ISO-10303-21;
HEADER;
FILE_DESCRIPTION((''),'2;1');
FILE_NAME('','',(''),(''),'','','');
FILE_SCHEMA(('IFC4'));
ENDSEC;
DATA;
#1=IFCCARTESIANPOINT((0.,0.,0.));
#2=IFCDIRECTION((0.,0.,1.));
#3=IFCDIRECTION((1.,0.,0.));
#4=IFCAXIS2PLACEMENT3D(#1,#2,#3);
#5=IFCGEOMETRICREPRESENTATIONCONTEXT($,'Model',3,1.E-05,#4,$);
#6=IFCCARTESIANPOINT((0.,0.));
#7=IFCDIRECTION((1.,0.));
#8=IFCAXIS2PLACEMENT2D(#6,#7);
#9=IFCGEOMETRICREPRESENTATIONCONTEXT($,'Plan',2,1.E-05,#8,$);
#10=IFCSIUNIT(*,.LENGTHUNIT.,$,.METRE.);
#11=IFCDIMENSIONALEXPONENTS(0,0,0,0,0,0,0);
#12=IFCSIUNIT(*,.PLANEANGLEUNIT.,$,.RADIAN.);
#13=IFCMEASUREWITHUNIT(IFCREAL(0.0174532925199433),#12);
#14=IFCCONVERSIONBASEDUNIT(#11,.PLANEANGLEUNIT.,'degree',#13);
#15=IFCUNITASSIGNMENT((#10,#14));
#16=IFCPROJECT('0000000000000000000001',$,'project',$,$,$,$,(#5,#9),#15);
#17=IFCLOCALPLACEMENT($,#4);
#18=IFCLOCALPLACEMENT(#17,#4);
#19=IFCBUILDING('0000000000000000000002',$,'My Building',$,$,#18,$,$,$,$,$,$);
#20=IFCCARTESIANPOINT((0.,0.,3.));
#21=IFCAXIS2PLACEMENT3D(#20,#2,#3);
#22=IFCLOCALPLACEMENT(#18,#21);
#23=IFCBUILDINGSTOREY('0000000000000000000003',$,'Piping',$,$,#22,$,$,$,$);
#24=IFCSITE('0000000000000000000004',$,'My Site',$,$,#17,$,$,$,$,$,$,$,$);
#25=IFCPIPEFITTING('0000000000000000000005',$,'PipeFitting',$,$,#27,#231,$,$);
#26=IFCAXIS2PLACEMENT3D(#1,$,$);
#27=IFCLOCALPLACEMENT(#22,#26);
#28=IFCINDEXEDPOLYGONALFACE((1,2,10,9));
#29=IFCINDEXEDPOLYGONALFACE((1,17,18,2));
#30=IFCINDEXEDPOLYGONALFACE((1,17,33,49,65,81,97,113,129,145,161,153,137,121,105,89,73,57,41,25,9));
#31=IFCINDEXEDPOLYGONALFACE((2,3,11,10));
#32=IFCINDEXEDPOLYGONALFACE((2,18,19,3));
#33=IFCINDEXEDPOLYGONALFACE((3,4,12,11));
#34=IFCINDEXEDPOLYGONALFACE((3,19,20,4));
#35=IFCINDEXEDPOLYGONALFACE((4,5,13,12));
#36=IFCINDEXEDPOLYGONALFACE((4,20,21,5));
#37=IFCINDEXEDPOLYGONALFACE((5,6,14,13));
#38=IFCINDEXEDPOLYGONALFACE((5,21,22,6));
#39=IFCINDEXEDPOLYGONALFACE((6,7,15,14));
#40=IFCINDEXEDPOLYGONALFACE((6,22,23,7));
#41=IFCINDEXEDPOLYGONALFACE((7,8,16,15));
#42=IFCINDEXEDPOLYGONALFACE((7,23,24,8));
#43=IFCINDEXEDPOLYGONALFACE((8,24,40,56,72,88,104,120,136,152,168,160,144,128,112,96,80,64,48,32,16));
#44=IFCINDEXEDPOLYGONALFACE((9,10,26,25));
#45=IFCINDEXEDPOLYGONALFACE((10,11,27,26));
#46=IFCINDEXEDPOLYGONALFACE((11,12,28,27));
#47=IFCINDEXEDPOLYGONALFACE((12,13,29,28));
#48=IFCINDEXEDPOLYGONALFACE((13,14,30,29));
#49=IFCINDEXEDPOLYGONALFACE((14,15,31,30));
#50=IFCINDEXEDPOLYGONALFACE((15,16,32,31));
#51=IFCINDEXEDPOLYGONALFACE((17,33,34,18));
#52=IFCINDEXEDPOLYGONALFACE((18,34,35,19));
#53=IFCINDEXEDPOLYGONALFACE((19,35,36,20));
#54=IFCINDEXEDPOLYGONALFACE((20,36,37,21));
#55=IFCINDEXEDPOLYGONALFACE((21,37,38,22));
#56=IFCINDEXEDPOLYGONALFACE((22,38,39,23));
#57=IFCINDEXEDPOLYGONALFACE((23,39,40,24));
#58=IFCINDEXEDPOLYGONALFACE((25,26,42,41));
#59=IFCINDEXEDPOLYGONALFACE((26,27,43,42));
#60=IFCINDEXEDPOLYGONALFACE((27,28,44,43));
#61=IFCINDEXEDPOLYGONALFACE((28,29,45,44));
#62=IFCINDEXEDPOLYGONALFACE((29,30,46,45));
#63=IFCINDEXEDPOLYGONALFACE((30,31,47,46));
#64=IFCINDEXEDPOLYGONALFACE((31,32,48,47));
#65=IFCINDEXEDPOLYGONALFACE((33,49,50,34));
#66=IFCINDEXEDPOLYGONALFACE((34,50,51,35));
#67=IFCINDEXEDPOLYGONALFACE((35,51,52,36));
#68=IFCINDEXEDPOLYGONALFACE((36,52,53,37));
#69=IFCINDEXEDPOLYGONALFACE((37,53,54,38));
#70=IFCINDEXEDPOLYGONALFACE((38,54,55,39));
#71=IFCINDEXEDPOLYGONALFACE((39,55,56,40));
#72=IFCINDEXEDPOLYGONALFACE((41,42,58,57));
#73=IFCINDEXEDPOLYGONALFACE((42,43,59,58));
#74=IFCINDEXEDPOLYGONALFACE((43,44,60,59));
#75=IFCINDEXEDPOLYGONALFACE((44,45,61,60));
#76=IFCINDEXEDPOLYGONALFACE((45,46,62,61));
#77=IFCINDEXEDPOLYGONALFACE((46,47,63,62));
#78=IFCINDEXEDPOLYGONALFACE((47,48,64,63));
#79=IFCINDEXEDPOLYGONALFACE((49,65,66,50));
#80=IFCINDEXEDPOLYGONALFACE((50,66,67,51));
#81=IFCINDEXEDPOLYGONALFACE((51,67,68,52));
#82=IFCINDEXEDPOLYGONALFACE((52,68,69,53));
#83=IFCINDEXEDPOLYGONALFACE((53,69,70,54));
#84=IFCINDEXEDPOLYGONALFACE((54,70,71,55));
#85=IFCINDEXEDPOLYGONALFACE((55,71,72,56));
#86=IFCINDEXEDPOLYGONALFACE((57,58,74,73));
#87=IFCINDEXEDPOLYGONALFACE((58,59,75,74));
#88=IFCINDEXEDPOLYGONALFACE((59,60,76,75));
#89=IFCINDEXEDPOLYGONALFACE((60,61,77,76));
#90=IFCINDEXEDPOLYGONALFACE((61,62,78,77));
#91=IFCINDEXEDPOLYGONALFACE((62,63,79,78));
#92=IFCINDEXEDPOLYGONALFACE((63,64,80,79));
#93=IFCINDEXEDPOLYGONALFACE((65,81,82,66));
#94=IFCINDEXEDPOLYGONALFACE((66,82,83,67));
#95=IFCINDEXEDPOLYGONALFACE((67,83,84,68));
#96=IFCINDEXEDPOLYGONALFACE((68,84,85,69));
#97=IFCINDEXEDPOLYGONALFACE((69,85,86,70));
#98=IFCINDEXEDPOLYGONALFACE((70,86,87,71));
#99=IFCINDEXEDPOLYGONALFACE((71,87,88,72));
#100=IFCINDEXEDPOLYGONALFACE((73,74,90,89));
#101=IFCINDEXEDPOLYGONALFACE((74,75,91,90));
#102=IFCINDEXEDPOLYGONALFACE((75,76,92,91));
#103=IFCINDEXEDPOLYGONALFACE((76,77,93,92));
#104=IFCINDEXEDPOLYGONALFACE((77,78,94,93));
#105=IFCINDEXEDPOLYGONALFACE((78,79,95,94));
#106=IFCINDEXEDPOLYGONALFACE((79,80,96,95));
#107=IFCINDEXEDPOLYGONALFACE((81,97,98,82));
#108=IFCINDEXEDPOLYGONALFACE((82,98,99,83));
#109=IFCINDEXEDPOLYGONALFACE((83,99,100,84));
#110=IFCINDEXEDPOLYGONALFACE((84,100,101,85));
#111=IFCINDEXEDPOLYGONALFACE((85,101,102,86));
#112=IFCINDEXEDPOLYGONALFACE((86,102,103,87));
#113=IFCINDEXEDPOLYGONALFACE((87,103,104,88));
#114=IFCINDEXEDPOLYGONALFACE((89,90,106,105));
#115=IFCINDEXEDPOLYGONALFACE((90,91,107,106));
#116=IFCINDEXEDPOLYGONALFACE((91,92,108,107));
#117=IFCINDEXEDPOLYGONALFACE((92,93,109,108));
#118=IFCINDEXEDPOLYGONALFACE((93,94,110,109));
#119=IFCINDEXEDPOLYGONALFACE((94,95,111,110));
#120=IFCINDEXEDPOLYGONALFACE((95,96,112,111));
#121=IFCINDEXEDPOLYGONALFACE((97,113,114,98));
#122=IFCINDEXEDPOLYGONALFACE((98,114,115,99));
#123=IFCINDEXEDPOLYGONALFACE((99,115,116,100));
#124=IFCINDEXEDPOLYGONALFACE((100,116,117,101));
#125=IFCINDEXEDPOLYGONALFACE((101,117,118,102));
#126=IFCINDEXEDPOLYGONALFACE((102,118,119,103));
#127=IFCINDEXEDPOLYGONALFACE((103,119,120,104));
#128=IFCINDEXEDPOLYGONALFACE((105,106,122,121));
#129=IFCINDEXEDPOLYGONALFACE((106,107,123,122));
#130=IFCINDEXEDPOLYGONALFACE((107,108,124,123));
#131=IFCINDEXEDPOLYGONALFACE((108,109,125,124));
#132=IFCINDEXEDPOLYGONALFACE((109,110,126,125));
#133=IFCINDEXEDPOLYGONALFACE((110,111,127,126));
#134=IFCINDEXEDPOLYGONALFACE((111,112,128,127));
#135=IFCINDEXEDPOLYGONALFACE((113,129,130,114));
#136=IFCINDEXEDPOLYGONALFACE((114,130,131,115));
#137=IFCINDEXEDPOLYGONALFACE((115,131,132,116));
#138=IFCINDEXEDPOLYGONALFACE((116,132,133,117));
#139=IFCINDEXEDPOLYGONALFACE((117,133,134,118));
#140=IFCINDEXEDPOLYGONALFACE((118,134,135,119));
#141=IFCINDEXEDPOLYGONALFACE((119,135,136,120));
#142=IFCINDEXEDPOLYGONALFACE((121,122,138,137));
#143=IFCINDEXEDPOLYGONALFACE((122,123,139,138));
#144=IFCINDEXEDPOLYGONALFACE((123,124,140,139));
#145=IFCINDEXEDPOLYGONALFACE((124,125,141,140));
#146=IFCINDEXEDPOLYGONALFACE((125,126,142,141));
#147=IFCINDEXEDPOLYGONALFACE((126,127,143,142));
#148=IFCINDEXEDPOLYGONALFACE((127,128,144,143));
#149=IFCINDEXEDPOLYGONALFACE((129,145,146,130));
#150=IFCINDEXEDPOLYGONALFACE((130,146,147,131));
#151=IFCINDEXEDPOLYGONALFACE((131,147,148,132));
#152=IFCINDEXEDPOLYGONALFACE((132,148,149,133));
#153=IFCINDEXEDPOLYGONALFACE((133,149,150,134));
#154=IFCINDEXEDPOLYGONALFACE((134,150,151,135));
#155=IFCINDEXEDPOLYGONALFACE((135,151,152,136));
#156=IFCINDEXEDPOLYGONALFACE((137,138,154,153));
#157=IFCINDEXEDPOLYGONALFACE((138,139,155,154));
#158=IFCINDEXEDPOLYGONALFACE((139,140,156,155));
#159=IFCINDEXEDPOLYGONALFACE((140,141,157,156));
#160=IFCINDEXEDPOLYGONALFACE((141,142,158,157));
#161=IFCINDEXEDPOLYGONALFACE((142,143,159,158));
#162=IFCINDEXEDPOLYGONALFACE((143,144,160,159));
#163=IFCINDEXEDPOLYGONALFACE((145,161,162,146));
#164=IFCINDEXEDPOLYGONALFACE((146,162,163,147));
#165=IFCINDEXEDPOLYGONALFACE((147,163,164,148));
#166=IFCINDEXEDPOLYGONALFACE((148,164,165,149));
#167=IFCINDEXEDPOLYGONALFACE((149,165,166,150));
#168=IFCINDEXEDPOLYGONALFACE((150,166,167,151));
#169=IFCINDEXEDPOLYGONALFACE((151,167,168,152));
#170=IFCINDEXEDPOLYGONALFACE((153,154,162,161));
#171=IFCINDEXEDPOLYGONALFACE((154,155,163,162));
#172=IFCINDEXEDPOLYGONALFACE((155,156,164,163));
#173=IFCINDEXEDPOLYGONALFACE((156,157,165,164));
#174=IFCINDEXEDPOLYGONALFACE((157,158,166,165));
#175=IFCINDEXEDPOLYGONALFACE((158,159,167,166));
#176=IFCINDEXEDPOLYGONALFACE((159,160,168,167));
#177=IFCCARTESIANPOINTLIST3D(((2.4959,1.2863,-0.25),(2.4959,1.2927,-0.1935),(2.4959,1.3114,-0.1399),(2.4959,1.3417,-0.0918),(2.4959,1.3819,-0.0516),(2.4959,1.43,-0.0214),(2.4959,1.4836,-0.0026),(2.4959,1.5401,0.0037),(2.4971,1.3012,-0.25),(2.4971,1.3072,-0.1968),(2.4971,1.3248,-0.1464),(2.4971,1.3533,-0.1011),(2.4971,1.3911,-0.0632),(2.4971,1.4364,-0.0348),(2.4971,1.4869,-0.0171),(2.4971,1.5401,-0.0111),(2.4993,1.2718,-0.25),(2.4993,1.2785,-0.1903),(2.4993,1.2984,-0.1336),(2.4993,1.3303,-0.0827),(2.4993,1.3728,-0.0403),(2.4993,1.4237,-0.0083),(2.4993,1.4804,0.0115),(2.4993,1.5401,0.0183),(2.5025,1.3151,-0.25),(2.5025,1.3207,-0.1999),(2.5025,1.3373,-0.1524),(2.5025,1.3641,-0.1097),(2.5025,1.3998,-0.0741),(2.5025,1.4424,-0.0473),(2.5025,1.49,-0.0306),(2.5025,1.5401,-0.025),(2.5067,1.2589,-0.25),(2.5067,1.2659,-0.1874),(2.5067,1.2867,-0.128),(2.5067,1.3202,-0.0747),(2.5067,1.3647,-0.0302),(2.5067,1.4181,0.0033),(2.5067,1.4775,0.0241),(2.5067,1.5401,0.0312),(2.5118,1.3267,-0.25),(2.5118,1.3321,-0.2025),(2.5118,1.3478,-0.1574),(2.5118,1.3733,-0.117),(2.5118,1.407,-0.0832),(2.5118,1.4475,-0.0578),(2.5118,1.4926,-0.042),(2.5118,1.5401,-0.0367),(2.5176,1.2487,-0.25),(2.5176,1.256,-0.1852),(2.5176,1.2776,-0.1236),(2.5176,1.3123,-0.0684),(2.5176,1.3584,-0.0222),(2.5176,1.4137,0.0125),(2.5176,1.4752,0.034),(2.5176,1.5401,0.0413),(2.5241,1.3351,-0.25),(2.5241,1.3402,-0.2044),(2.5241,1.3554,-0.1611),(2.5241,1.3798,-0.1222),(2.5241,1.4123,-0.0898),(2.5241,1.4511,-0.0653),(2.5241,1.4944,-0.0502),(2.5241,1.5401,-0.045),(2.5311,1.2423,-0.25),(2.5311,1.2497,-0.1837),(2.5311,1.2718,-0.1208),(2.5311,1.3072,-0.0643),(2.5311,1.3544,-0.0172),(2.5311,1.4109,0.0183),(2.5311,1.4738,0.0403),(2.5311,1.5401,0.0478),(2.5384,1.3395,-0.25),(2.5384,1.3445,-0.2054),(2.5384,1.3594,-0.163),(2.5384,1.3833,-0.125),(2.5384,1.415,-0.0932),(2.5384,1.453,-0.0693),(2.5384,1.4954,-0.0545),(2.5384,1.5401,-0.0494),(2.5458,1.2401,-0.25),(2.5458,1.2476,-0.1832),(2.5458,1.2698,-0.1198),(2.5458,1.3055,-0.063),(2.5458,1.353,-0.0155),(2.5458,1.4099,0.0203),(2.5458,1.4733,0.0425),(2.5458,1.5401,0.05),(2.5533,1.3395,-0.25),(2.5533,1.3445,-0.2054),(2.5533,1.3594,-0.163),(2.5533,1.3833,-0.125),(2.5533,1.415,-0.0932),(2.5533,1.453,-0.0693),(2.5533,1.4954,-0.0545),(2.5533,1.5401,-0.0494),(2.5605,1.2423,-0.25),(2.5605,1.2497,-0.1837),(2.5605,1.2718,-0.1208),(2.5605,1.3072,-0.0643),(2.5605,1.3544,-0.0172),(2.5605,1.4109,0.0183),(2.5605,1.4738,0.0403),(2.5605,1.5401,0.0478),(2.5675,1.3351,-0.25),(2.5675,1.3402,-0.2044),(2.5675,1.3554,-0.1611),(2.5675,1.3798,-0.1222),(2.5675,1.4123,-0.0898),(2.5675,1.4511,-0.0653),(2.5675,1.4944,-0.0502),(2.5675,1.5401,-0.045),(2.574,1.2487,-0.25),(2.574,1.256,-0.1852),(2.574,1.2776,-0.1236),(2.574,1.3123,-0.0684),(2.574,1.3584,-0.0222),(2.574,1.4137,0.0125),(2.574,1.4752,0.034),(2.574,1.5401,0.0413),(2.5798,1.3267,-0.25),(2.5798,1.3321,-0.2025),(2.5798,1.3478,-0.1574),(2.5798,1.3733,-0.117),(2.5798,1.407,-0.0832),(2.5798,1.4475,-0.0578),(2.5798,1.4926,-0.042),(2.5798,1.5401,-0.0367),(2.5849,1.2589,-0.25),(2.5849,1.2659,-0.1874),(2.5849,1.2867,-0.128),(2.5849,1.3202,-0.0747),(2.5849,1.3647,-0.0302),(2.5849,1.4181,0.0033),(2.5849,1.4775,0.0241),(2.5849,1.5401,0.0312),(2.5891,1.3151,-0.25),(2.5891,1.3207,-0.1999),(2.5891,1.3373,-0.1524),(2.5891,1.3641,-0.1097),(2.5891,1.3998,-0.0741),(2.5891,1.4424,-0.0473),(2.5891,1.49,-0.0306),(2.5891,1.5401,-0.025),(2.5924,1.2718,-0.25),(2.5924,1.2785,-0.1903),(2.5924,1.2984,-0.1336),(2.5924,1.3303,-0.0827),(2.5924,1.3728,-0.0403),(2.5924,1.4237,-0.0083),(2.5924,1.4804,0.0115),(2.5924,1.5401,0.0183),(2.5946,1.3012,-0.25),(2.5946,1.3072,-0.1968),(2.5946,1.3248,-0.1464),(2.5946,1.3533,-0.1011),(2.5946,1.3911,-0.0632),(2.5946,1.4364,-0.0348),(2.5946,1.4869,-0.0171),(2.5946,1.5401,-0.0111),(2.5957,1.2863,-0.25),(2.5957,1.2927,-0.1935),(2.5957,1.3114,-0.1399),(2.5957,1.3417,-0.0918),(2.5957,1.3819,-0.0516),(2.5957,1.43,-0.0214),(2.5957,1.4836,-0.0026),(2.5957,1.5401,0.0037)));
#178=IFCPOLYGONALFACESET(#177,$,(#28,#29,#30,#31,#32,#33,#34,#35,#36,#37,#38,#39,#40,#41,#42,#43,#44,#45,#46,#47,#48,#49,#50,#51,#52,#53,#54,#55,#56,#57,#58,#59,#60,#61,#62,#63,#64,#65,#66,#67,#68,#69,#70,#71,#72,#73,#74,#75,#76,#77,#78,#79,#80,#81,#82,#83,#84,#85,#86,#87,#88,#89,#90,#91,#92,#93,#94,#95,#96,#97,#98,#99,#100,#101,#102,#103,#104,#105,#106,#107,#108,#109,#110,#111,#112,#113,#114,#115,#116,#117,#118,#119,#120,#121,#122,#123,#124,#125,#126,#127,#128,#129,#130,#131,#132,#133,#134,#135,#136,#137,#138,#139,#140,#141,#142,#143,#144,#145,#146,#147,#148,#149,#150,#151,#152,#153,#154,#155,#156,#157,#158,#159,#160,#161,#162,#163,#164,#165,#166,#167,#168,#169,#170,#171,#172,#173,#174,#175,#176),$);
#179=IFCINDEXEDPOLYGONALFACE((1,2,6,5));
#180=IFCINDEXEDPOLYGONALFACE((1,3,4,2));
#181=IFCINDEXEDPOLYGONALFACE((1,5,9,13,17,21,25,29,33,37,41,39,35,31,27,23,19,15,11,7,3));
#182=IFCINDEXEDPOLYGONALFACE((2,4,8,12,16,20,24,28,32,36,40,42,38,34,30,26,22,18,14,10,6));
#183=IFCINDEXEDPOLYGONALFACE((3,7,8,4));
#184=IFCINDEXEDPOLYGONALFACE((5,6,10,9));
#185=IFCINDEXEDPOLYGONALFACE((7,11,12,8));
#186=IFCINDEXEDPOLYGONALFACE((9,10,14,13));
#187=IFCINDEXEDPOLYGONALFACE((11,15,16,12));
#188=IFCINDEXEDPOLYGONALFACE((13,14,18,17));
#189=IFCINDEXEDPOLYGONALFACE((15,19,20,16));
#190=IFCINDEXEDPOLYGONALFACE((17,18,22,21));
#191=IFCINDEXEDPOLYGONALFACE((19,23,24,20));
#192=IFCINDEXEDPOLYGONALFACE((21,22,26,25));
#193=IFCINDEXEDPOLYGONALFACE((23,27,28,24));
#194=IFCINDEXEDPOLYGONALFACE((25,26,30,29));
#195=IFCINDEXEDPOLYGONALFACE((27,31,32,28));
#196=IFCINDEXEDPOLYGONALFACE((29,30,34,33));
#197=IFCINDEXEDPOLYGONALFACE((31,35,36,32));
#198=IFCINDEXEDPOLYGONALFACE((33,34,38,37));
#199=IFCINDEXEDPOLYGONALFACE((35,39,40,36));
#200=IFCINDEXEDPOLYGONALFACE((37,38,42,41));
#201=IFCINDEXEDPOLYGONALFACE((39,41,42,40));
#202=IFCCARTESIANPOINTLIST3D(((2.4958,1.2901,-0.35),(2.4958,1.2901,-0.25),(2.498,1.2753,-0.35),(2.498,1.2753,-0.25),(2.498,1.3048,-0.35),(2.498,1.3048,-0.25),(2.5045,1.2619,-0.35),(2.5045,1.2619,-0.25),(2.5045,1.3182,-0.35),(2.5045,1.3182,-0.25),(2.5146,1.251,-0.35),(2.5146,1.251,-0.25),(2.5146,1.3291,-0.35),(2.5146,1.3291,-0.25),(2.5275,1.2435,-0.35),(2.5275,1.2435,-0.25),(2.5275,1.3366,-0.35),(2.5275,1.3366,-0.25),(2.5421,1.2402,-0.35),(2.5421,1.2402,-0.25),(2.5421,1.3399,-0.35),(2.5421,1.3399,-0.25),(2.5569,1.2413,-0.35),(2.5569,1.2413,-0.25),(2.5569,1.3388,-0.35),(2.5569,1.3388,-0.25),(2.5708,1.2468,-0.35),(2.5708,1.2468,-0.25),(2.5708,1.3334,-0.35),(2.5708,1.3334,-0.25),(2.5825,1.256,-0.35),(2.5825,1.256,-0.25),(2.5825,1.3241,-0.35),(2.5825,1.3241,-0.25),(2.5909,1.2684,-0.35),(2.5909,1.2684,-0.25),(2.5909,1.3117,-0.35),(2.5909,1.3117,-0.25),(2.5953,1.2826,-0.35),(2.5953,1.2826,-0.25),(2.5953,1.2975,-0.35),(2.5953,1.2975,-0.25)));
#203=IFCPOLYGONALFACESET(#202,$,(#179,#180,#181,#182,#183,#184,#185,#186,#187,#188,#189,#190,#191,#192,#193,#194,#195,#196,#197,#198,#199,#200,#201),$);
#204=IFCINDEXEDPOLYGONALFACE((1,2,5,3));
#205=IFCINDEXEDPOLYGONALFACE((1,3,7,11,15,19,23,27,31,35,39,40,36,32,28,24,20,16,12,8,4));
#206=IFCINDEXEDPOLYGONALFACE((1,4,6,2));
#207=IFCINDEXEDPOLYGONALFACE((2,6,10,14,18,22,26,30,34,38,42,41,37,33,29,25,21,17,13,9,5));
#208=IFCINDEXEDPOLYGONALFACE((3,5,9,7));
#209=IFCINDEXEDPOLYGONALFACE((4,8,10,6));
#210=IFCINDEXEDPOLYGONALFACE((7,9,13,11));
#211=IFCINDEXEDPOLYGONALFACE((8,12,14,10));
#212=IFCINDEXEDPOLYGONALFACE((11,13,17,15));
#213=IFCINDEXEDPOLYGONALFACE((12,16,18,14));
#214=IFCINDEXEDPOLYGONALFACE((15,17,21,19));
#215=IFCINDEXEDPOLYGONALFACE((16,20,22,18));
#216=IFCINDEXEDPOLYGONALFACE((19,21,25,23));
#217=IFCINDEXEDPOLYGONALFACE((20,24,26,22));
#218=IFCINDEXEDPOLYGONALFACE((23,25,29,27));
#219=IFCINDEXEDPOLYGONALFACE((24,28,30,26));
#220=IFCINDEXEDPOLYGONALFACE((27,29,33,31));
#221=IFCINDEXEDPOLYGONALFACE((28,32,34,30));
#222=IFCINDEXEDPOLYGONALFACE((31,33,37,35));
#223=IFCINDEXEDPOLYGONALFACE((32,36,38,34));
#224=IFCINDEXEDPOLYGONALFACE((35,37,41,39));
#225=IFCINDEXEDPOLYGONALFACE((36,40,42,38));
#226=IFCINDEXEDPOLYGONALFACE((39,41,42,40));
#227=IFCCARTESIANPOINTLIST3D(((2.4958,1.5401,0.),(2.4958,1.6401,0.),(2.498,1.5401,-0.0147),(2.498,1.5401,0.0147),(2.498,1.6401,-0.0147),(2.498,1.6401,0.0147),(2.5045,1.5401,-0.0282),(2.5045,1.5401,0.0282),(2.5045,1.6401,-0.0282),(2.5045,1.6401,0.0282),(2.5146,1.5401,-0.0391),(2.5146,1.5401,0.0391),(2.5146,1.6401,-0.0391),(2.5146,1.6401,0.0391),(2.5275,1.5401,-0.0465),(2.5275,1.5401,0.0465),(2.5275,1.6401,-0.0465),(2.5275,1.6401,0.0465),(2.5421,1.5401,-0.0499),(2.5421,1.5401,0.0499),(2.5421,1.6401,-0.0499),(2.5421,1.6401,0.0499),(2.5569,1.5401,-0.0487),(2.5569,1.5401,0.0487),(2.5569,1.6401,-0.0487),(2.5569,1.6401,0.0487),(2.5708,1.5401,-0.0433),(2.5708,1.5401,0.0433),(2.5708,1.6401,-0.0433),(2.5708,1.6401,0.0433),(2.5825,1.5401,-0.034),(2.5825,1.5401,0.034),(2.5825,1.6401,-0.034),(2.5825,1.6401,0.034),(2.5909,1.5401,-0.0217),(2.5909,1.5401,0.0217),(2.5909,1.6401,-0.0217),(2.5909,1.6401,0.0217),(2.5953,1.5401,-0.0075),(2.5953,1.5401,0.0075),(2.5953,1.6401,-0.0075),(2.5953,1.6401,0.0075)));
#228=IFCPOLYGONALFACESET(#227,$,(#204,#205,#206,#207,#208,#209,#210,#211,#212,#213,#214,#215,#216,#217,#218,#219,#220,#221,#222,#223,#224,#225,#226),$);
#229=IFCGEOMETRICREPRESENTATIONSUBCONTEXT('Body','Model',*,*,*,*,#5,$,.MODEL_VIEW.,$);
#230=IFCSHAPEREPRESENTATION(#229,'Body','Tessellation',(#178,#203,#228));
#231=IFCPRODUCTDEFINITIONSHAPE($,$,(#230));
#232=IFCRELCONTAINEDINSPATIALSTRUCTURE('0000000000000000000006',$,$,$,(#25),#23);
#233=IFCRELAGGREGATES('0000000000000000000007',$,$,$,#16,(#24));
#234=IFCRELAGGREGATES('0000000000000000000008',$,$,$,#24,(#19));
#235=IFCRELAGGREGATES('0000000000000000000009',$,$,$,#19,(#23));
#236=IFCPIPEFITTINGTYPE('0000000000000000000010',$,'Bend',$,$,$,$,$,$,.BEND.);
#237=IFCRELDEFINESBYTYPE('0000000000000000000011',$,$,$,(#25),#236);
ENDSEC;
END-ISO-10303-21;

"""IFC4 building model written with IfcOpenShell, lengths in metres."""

from ifc_helpers import new_model, entity, si_unit, converted_unit, frame, origin_with_axes, origin_2d_with_axis, place, context, subcontext, project, spatial, circle, extrude, source, transform, mapped, type_object, type_shapes, element, save


model = new_model("IFC4")

# Units and contexts
model_context = context("Model", 3, precision=1e-05, world=origin_with_axes())
plan_context = context("Plan", 2, precision=1e-05, world=origin_2d_with_axis())
body_context = subcontext(model_context, "Body", "Model", "MODEL_VIEW")
ifc_project = project(units=[si_unit("LENGTHUNIT", "METRE"), converted_unit("PLANEANGLEUNIT", "degree", entity("IfcReal", 0.0174532925199433), si_unit("PLANEANGLEUNIT", "RADIAN"), dimensions=[0, 0, 0, 0, 0, 0, 0])], contexts=[model_context, plan_context])

# Site, building, storey
site_placement = place(None, origin_with_axes())
site = spatial("IfcSite", under=ifc_project, at=site_placement, Name="My Site")
building_placement = place(site_placement, origin_with_axes())
building = spatial("IfcBuilding", under=site, at=building_placement, Name="My Building")
storey_placement = place(building_placement, frame((0.0, 0.0, 3.0), z_axis=(0.0, 0.0, 1.0), x_axis=(1.0, 0.0, 0.0)))
storey = spatial("IfcBuildingStorey", under=building, at=storey_placement, Name="Piping")

# Pipe fitting
pipe_fitting_type = type_object("IfcPipeFittingType", Name="Bend", PredefinedType="BEND")
shared_shape = source(origin_with_axes(), body_context, "Body", "SolidModel", [
    entity("IfcSweptDiskSolid", entity("IfcIndexedPolyCurve", entity("IfcCartesianPointList3D", [[0.0, 0.0, -0.1], [0.0, 0.0732, -0.2768], [0.0, 0.25, -0.35]]), [entity("IfcArcIndex", [1, 2, 3])]), 0.05),
    extrude(circle(Radius=0.05), origin_with_axes(), (0.0, 0.0, -1.0), 0.1),
    extrude(circle(Radius=0.05), frame((0.0, 0.25, -0.35), z_axis=(0.0, 1.0, 0.0), x_axis=(1.0, 0.0, 0.0)), (0.0, 0.0, 1.0), 0.1),
])
type_shapes(pipe_fitting_type, [shared_shape])
pipe_fitting_placement = place(storey_placement, frame((2.5458, 1.2901, -0.35), z_axis=(0.0, 0.0, -1.0), x_axis=(-1.0, 0.0, 0.0)))
element("IfcPipeFitting", 1, at=pipe_fitting_placement, inside=storey, type_object=pipe_fitting_type, Name="PipeFitting", context=body_context, shape_type="MappedRepresentation", body=[
    mapped(shared_shape, transform((0.0, 0.0, 0.0), x_axis=(1.0, 0.0, 0.0), y_axis=(0.0, 1.0, 0.0), z_axis=(0.0, 0.0, 1.0), scale=1.0)),
])

save(model, "model.ifc")
